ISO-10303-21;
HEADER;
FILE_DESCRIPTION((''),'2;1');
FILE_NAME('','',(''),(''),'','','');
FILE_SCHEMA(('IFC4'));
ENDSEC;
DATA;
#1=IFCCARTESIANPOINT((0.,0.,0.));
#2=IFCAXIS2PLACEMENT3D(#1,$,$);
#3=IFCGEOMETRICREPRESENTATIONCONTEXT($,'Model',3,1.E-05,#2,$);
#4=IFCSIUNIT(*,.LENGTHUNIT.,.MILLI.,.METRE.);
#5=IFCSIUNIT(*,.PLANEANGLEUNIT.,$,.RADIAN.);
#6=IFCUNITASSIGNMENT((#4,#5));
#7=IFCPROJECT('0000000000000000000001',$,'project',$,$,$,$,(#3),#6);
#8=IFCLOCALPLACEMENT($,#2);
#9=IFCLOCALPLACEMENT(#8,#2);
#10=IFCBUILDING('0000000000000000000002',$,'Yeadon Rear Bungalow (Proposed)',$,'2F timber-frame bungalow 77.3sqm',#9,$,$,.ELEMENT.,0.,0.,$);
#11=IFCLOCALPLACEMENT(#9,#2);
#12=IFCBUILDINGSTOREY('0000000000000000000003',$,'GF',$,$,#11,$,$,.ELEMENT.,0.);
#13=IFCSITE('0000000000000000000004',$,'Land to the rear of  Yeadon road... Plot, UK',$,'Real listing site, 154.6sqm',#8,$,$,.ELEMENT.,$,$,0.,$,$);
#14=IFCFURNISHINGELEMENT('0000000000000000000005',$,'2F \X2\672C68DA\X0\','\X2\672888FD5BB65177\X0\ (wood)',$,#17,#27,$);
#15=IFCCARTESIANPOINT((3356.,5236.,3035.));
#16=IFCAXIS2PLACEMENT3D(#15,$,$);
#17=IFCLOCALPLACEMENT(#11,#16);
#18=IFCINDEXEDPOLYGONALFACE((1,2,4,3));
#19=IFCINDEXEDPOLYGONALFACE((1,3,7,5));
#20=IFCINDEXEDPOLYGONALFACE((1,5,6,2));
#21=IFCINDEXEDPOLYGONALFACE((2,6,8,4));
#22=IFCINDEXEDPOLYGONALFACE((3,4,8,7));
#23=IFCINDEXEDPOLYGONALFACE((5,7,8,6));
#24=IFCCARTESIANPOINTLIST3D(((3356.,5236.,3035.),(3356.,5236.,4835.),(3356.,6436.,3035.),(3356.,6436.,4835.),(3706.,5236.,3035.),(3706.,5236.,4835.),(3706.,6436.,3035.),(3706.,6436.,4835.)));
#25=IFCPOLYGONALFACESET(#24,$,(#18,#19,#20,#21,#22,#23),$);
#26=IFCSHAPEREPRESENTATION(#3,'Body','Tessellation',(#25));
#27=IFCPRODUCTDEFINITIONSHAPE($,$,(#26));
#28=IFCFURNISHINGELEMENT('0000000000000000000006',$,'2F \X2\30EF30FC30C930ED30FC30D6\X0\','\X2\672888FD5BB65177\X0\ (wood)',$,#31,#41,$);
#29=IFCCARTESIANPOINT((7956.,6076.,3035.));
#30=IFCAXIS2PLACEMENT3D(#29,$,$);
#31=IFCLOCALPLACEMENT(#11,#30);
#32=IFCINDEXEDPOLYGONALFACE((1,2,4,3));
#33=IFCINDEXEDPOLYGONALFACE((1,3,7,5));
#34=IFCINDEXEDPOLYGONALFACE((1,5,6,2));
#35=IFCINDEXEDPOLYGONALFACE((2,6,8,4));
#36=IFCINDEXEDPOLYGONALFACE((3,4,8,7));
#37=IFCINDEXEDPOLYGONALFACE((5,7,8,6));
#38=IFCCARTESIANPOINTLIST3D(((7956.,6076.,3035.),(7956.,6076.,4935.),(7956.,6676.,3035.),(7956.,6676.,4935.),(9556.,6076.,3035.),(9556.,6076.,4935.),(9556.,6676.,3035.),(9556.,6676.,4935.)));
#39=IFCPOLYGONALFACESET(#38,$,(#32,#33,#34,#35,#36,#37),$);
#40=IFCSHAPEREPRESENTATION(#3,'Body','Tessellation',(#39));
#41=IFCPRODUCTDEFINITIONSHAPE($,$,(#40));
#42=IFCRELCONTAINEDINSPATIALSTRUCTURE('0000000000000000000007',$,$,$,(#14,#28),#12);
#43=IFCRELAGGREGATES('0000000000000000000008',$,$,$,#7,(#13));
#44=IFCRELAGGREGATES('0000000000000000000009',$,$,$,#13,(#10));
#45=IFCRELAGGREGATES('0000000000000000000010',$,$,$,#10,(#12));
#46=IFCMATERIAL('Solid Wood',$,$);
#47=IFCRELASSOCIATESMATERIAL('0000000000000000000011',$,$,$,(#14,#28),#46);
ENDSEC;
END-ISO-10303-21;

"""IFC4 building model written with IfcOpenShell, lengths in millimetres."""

from ifc_helpers import new_model, si_unit, frame, frame_2d, origin, place, context, project, spatial, rectangle, extrude, material, element, save


model = new_model("IFC4")

# Units and contexts
model_context = context("Model", 3, precision=1e-05, world=origin())
ifc_project = project(units=[si_unit("LENGTHUNIT", "METRE", prefix="MILLI"), si_unit("PLANEANGLEUNIT", "RADIAN")], contexts=[model_context])

# Site, building, storey
site_placement = place(None, origin())
site = spatial("IfcSite", under=ifc_project, at=site_placement, Name="Land to the rear of  Yeadon road... Plot, UK", ObjectType="Real listing site, 154.6sqm", CompositionType="ELEMENT", RefElevation=0.0)
building_placement = place(site_placement, origin())
building = spatial("IfcBuilding", under=site, at=building_placement, Name="Yeadon Rear Bungalow (Proposed)", ObjectType="2F timber-frame bungalow 77.3sqm", CompositionType="ELEMENT", ElevationOfRefHeight=0.0, ElevationOfTerrain=0.0)
storey_placement = place(building_placement, origin())
storey = spatial("IfcBuildingStorey", under=building, at=storey_placement, Name="GF", CompositionType="ELEMENT", Elevation=0.0)

# Shared definitions
ifc_material_1 = material(Name="Solid Wood")

# Furnishing elements
furnishing_1_placement = place(storey_placement, frame((3356.0, 5236.0, 3035.0)))
element("IfcFurnishingElement", 1, at=furnishing_1_placement, inside=storey, material=ifc_material_1, Name="2F 本棚", Description="木製家具 (wood)", context=model_context, shape_type="SweptSolid", body=[
    extrude(rectangle(XDim=350.0, YDim=1200.0, at=frame_2d((175.0, 600.0))), frame((3356.0, 5236.0, 3035.0)), (0.0, 0.0, 1.0), 1800.0),
])
furnishing_2_placement = place(storey_placement, frame((7956.0, 6076.0, 3035.0)))
element("IfcFurnishingElement", 2, at=furnishing_2_placement, inside=storey, material=ifc_material_1, Name="2F ワードローブ", Description="木製家具 (wood)", context=model_context, shape_type="SweptSolid", body=[
    extrude(rectangle(XDim=1600.0, YDim=600.0, at=frame_2d((800.0, 300.0))), frame((7956.0, 6076.0, 3035.0)), (0.0, 0.0, 1.0), 1900.0),
])

save(model, "model.ifc")
